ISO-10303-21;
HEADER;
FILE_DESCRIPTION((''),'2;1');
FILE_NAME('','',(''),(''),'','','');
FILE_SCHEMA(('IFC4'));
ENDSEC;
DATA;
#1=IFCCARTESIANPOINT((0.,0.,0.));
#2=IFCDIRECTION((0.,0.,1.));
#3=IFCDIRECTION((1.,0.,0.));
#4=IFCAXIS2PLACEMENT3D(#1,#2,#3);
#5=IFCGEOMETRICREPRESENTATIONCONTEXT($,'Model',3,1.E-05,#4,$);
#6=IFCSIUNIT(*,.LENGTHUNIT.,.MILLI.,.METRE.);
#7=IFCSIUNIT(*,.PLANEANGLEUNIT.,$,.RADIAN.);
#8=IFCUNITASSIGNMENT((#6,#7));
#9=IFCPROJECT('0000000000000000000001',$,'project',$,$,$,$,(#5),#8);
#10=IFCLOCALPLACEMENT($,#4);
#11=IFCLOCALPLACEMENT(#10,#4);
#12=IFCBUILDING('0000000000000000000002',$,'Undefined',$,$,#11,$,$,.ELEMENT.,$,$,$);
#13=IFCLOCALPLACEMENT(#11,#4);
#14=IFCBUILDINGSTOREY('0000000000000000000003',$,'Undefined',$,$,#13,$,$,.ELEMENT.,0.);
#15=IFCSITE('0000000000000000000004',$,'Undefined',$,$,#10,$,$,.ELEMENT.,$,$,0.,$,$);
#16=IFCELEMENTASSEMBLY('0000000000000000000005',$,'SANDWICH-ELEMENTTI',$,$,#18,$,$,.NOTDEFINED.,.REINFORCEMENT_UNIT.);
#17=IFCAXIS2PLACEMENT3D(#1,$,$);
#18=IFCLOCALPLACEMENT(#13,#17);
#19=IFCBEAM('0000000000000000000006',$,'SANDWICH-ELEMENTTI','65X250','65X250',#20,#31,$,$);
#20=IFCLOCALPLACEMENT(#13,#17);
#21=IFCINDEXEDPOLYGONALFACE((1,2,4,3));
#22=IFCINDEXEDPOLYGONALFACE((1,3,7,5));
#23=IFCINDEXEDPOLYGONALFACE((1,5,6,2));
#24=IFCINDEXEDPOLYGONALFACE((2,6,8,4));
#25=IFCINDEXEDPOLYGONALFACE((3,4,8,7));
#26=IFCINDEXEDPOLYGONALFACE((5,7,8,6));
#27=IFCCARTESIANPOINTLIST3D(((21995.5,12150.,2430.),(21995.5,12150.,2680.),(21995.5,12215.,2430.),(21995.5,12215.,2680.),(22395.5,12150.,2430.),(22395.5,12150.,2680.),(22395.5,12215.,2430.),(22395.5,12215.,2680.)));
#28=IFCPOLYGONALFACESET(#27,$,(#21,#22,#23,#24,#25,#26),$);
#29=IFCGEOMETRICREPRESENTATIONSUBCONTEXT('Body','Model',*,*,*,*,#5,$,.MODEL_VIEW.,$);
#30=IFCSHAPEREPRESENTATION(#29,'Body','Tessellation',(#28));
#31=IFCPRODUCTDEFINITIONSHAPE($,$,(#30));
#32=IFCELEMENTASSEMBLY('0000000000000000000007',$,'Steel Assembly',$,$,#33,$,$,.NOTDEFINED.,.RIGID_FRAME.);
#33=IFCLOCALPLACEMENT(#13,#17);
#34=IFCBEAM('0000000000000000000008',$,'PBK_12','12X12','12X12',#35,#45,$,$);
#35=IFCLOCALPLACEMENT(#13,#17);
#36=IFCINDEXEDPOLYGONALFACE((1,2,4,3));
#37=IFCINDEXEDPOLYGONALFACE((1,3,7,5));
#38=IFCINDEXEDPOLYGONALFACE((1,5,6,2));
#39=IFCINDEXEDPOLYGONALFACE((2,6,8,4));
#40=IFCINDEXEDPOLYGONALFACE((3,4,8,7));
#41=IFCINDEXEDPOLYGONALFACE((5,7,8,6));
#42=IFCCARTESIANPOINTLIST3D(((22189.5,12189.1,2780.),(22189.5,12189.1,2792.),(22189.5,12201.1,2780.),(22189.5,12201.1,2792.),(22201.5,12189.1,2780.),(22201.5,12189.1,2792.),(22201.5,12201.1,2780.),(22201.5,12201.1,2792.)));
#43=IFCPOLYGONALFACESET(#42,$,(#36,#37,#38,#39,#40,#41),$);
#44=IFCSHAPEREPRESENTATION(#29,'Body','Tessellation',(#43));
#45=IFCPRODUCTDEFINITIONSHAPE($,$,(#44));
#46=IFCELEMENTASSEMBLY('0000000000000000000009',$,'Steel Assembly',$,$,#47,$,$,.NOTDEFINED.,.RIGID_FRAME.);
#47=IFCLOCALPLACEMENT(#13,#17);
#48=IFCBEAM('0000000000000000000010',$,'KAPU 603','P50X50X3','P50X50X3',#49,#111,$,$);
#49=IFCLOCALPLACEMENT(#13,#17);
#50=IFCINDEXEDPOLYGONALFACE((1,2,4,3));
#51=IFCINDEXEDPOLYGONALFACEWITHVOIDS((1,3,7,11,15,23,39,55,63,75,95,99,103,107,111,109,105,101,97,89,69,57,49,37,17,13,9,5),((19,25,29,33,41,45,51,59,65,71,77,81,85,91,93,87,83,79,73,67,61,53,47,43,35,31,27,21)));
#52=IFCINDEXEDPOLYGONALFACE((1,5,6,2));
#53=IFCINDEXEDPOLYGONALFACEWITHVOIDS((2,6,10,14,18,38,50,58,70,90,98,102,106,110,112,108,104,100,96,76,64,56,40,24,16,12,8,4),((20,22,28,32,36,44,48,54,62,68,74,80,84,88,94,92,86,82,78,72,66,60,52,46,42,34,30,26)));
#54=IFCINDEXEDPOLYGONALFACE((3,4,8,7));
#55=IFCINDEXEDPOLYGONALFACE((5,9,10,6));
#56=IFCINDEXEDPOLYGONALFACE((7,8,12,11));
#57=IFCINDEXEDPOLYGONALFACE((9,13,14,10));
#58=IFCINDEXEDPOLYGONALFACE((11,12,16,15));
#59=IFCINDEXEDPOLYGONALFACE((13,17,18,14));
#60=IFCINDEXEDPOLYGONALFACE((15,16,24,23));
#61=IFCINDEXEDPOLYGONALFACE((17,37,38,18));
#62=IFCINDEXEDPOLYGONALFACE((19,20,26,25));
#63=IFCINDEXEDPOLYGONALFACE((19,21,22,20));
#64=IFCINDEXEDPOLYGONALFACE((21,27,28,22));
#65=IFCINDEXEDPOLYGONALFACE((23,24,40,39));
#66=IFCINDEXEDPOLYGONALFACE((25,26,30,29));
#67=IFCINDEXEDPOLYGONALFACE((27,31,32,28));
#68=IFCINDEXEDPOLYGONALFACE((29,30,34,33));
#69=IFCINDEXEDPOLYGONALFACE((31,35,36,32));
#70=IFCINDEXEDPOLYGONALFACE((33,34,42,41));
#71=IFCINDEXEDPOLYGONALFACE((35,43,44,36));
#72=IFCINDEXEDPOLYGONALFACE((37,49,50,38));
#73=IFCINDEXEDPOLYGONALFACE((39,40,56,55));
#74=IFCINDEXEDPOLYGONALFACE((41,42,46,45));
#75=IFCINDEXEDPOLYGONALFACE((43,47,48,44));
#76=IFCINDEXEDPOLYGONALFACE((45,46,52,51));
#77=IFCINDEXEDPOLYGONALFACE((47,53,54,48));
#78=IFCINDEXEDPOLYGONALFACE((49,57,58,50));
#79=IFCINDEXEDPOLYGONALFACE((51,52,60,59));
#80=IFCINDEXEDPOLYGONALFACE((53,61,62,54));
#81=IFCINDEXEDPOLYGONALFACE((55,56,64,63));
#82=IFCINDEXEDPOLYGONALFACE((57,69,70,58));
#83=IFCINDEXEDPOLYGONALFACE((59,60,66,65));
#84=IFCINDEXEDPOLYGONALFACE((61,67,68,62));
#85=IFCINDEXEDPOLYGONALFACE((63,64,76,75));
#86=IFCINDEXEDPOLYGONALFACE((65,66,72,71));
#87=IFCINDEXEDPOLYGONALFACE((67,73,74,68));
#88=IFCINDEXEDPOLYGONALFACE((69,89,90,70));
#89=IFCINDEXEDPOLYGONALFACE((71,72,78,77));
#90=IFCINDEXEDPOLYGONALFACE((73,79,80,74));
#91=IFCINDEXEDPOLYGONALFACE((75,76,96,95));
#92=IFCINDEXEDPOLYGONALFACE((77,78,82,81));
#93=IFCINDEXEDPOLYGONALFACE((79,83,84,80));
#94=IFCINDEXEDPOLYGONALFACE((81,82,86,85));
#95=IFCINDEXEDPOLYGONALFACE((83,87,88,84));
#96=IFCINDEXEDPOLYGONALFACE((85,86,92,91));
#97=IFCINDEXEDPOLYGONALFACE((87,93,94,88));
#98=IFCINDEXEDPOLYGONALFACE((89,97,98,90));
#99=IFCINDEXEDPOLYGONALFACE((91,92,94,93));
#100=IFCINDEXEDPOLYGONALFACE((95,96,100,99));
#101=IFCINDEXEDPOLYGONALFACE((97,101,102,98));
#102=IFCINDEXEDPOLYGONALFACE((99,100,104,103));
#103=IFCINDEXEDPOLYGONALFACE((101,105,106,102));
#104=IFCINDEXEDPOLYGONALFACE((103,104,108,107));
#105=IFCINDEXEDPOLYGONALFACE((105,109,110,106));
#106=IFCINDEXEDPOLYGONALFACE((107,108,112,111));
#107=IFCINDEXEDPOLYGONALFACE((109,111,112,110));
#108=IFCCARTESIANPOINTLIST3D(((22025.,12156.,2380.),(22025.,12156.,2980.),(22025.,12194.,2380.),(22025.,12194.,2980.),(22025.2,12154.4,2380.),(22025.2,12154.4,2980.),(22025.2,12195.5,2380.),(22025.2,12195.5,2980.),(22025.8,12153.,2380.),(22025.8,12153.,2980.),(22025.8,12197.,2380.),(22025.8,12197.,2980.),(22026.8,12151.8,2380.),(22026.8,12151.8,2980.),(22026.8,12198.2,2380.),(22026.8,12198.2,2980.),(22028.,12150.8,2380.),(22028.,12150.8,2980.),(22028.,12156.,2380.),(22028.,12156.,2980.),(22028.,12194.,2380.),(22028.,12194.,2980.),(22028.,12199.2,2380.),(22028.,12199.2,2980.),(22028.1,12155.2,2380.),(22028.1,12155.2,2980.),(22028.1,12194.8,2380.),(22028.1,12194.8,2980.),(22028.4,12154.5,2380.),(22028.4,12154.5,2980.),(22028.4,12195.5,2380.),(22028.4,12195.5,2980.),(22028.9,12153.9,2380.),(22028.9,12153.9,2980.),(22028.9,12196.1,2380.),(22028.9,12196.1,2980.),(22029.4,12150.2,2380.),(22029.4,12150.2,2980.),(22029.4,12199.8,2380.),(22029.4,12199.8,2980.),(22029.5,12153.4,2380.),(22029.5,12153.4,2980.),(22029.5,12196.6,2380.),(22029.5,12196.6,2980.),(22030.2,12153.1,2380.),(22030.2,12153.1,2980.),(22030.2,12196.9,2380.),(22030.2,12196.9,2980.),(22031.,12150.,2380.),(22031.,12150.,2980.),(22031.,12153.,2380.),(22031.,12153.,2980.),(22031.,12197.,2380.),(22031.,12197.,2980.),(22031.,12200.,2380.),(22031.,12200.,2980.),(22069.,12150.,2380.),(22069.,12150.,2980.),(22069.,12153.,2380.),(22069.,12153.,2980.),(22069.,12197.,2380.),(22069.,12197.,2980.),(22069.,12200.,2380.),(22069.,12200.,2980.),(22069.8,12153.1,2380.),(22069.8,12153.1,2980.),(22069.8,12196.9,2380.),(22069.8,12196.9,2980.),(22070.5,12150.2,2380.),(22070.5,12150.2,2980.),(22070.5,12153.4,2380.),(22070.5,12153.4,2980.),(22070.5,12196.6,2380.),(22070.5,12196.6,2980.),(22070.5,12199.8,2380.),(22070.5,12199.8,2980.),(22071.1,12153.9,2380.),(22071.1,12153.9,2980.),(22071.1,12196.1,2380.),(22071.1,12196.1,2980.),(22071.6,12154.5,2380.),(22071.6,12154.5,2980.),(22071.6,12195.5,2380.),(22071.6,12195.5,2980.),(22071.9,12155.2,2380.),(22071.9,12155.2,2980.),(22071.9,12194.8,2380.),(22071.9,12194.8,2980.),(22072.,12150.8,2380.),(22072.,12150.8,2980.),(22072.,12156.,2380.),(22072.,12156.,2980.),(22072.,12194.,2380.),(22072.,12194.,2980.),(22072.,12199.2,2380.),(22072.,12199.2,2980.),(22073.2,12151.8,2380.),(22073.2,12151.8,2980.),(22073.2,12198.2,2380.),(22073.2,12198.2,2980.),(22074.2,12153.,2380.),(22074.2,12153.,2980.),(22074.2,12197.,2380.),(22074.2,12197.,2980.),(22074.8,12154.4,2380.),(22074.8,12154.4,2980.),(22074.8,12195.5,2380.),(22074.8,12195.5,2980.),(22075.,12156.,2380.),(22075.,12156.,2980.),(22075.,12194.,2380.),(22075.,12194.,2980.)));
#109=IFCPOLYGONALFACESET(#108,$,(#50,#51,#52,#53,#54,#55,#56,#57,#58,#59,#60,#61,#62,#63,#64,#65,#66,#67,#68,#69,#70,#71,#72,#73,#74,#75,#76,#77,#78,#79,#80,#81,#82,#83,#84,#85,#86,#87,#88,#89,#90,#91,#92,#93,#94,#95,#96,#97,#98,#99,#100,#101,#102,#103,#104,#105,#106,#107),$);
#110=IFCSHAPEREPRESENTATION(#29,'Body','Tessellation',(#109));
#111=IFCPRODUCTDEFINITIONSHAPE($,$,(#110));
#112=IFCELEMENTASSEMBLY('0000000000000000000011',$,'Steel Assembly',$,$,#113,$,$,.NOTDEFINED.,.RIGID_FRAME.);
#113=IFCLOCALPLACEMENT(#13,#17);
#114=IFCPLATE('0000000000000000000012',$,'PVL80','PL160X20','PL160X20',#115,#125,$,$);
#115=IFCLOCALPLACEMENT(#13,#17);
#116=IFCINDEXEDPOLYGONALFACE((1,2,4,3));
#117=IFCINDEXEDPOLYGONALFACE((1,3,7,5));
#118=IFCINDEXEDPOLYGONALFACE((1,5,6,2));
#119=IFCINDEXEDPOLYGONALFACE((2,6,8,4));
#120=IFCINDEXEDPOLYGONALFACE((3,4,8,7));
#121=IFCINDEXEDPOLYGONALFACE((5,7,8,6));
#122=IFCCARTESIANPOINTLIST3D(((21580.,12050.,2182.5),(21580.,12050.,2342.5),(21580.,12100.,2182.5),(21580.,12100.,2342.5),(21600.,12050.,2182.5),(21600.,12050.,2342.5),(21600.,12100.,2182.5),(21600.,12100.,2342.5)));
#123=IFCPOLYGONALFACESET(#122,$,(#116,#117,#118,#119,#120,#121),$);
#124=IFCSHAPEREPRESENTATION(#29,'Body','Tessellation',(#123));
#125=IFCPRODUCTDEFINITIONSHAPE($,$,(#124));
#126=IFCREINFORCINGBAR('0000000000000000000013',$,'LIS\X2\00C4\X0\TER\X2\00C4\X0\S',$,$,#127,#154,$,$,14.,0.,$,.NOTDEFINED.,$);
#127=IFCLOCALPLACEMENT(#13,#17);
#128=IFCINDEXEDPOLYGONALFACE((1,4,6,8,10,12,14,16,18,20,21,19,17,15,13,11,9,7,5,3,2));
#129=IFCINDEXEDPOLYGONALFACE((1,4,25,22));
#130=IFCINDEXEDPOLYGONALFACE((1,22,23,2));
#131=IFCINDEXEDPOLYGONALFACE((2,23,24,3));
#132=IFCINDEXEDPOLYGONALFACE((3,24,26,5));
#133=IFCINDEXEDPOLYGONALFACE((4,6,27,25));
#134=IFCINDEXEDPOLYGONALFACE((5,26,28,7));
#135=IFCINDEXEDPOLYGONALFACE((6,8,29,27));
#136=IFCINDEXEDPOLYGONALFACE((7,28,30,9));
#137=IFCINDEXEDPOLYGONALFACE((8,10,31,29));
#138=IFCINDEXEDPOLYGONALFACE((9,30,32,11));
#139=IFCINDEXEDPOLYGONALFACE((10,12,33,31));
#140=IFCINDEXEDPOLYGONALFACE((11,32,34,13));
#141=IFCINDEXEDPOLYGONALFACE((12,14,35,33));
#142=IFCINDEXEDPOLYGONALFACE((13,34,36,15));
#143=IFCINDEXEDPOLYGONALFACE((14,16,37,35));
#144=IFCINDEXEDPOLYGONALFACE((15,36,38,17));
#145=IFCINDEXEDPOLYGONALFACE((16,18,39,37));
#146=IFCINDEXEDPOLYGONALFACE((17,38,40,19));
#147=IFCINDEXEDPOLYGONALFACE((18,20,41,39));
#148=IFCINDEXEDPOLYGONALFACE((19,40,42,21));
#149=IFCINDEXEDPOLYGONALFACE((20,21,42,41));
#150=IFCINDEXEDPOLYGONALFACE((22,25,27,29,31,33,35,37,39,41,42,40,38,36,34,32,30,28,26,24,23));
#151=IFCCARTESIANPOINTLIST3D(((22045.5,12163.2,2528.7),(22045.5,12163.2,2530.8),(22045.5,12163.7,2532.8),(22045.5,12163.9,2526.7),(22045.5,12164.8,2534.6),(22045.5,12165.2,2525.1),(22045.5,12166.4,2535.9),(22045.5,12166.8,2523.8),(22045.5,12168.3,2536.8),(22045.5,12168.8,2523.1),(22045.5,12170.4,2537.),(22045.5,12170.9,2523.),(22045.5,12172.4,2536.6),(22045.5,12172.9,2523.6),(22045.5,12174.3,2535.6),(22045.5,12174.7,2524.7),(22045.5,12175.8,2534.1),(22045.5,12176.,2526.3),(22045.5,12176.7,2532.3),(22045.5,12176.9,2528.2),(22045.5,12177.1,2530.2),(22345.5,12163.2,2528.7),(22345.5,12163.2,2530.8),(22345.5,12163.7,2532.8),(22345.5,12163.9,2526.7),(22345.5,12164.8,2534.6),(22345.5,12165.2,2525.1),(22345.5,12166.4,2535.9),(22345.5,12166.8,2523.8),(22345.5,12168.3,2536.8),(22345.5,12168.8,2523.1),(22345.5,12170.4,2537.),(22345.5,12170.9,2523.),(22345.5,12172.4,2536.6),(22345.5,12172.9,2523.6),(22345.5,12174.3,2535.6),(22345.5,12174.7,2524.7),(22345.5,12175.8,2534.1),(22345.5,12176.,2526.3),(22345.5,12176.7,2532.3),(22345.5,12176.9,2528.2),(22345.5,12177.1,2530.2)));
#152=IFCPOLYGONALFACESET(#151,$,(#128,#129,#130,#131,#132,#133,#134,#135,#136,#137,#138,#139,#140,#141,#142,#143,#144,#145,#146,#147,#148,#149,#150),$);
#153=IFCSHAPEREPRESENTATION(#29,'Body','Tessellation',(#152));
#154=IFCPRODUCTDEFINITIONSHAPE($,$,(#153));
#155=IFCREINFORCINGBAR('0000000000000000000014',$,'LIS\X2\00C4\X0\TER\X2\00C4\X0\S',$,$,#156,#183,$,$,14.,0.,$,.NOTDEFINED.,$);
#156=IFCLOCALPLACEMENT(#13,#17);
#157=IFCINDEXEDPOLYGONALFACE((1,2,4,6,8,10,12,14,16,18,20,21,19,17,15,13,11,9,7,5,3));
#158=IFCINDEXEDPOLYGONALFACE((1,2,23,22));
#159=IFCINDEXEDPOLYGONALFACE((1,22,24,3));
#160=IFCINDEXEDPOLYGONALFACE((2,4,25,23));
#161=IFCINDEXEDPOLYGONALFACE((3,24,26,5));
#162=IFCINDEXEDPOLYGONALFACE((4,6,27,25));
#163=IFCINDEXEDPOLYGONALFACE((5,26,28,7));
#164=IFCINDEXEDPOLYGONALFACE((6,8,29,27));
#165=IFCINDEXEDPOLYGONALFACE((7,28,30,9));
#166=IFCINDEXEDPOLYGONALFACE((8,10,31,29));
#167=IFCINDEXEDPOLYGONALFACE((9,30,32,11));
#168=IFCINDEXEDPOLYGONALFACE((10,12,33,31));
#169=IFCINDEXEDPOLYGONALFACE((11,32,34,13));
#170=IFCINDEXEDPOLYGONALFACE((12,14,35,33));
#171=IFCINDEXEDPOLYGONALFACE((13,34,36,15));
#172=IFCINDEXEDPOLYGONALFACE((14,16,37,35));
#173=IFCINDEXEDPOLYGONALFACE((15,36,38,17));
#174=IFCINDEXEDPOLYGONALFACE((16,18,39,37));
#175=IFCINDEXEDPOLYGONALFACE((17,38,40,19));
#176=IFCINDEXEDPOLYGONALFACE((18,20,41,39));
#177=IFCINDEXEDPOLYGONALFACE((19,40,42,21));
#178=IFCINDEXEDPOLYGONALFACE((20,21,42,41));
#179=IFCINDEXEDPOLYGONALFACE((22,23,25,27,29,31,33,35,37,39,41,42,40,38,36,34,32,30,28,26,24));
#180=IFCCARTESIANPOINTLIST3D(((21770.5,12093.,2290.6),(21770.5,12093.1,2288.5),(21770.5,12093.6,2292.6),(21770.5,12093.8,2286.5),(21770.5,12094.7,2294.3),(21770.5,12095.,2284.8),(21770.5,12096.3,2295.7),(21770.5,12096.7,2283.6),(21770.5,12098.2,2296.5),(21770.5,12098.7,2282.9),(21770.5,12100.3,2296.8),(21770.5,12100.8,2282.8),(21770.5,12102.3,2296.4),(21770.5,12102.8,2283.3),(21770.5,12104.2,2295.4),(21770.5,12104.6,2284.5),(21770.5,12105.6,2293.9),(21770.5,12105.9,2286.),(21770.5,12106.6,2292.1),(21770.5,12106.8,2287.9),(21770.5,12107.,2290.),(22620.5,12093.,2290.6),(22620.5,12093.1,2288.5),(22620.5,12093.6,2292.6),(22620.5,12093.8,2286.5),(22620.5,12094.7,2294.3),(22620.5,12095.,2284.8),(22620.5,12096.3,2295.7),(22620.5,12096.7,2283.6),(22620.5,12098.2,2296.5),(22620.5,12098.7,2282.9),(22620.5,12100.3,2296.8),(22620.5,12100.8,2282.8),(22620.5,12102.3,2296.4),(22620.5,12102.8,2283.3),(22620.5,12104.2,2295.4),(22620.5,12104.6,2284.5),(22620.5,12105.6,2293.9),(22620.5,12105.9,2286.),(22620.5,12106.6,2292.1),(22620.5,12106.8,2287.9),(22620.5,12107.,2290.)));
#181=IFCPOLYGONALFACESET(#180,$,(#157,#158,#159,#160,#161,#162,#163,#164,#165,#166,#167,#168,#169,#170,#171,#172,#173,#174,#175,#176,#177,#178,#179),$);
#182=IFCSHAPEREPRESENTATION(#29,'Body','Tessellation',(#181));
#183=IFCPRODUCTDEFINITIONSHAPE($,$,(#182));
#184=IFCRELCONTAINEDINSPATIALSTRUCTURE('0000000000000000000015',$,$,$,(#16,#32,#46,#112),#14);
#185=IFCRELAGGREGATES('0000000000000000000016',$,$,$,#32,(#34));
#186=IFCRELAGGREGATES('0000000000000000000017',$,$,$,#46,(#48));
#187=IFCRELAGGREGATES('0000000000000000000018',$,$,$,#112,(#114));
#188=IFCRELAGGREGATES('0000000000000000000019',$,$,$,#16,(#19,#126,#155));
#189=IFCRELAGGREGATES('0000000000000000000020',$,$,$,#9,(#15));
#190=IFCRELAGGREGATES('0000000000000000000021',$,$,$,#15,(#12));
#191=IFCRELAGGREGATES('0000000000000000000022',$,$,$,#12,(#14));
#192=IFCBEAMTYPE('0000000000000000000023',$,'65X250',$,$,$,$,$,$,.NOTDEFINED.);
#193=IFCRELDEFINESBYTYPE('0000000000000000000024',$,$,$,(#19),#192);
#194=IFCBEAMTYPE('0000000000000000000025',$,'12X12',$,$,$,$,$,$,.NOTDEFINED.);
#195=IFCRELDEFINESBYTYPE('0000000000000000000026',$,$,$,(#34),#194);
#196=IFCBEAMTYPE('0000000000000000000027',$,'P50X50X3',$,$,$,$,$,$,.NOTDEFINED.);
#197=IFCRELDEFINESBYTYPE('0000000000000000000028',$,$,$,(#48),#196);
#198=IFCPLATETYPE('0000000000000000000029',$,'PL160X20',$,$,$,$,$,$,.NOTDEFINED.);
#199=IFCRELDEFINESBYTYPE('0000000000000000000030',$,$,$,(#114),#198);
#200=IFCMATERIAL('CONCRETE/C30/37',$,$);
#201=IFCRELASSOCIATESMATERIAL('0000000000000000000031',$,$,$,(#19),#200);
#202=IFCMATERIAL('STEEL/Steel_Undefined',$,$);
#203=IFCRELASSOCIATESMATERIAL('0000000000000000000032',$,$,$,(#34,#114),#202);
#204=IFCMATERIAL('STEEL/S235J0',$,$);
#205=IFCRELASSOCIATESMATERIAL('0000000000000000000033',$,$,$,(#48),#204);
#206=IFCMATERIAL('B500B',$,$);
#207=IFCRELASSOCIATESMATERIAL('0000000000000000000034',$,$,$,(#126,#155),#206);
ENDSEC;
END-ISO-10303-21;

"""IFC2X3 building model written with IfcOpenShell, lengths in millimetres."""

from ifc_helpers import new_model, entity, si_unit, frame, origin_with_axes, origin_2d_with_axis, place, context, subcontext, project, spatial, polyline, rectangle, hollow_rectangle, outline, extrude, source, transform, mapped, material, type_object, element, aggregate, save


model = new_model("IFC2X3")

# Units and contexts
model_context = context("Model", 3, precision=1e-05, world=origin_with_axes())
body_context = subcontext(model_context, "Body", "Model", "MODEL_VIEW")
ifc_project = project(units=[si_unit("LENGTHUNIT", "METRE", prefix="MILLI"), si_unit("PLANEANGLEUNIT", "RADIAN")], contexts=[model_context])

# Site, building, storey
site_placement = place(None, origin_with_axes())
site = spatial("IfcSite", under=ifc_project, at=site_placement, Name="Undefined", CompositionType="ELEMENT", RefElevation=0.0)
building_placement = place(site_placement, origin_with_axes())
building = spatial("IfcBuilding", under=site, at=building_placement, Name="Undefined", CompositionType="ELEMENT")
storey_placement = place(building_placement, origin_with_axes())
storey = spatial("IfcBuildingStorey", under=building, at=storey_placement, Name="Undefined", CompositionType="ELEMENT", Elevation=0.0)

# Element assemblies, beams
assembly_1_placement = place(storey_placement, origin_with_axes())
assembly_1 = element("IfcElementAssembly", 1, at=assembly_1_placement, inside=storey, Name="SANDWICH-ELEMENTTI", AssemblyPlace="NOTDEFINED", PredefinedType="REINFORCEMENT_UNIT")
ifc_material_1 = material(Name="CONCRETE/C30/37")
beam_type_1 = type_object("IfcBeamType", Name="65X250", PredefinedType="NOTDEFINED")
beam_1_placement = place(assembly_1_placement, frame((21995.5, 12182.5, 2555.0), z_axis=(0.0, -1.0, 0.0), x_axis=(1.0, 0.0, 0.0)))
beam_1 = element("IfcBeam", 2, at=beam_1_placement, type_object=beam_type_1, material=ifc_material_1, Name="SANDWICH-ELEMENTTI", Description="65X250", ObjectType="65X250", context=body_context, shape_type="SweptSolid", body=[
    extrude(rectangle(XDim=250.0, YDim=65.0, at=origin_2d_with_axis()), frame((400.0, 0.0, 0.0), z_axis=(-1.0, 0.0, 0.0), x_axis=(0.0, -1.0, 0.0)), (0.0, 0.0, 1.0), 400.0),
])
assembly_2_placement = place(storey_placement, origin_with_axes())
assembly_2 = element("IfcElementAssembly", 3, at=assembly_2_placement, inside=storey, Name="Steel Assembly", AssemblyPlace="NOTDEFINED", PredefinedType="RIGID_FRAME")
ifc_material_2 = material(Name="STEEL/Steel_Undefined")
beam_type_2 = type_object("IfcBeamType", Name="12X12", PredefinedType="NOTDEFINED")
beam_2_placement = place(assembly_2_placement, frame((22201.5, 12195.1, 2786.0), z_axis=(0.0, 0.0, 1.0), x_axis=(-1.0, 0.0, 0.0)))
beam_2 = element("IfcBeam", 4, at=beam_2_placement, type_object=beam_type_2, material=ifc_material_2, Name="PBK_12", Description="12X12", ObjectType="12X12", context=body_context, shape_type="SweptSolid", body=[
    extrude(rectangle(XDim=12.0, YDim=12.0, at=origin_2d_with_axis()), frame((12.0, 0.0, 0.0), z_axis=(-1.0, 0.0, 0.0), x_axis=(0.0, -1.0, 0.0)), (0.0, 0.0, 1.0), 12.0),
])
aggregate(assembly_2, [beam_2])
assembly_3_placement = place(storey_placement, origin_with_axes())
assembly_3 = element("IfcElementAssembly", 5, at=assembly_3_placement, inside=storey, Name="Steel Assembly", AssemblyPlace="NOTDEFINED", PredefinedType="RIGID_FRAME")
ifc_material_3 = material(Name="STEEL/S235J0")
beam_type_3 = type_object("IfcBeamType", Name="P50X50X3", PredefinedType="NOTDEFINED")
beam_3_placement = place(assembly_3_placement, frame((22050.0, 12175.0, 2980.0), z_axis=(1.0, 0.0, 0.0), x_axis=(0.0, 0.0, -1.0)))
beam_3 = element("IfcBeam", 6, at=beam_3_placement, type_object=beam_type_3, material=ifc_material_3, Name="KAPU 603", Description="P50X50X3", ObjectType="P50X50X3", context=body_context, shape_type="SweptSolid", body=[
    extrude(hollow_rectangle(XDim=50.0, YDim=50.0, WallThickness=3.0, InnerFilletRadius=3.0, OuterFilletRadius=6.0, at=origin_2d_with_axis()), frame((600.0, 0.0, 0.0), z_axis=(-1.0, 0.0, 0.0), x_axis=(0.0, -1.0, 0.0)), (0.0, 0.0, 1.0), 600.0),
])
aggregate(assembly_3, [beam_3])

# Element assembly, plate
assembly_4_placement = place(storey_placement, origin_with_axes())
assembly_4 = element("IfcElementAssembly", 7, at=assembly_4_placement, inside=storey, Name="Steel Assembly", AssemblyPlace="NOTDEFINED", PredefinedType="RIGID_FRAME")
plate_type = type_object("IfcPlateType", Name="PL160X20", PredefinedType="NOTDEFINED")
plate_placement = place(assembly_4_placement, frame((21580.0, 12050.0, 2262.5), z_axis=(0.0, 0.0, -1.0), x_axis=(0.0, 1.0, 0.0)))
plate = element("IfcPlate", 8, at=plate_placement, type_object=plate_type, material=ifc_material_2, Name="PVL80", Description="PL160X20", ObjectType="PL160X20", context=body_context, shape_type="SweptSolid", body=[
    extrude(outline(polyline([(0.0, 0.0), (50.0, 0.0), (50.0, 20.0), (0.0, 20.0), (0.0, 0.0)])), frame((0.0, 0.0, -80.0), z_axis=(0.0, 0.0, 1.0), x_axis=(1.0, 0.0, 0.0)), (0.0, 0.0, 1.0), 160.0),
])
aggregate(assembly_4, [plate])

# Reinforcing bars
ifc_material_4 = material(Name="B500B")
shared_shape_1 = source(origin_with_axes(), body_context, "Body", "AdvancedSweptSolid", [
    entity("IfcSweptDiskSolid", entity("IfcTrimmedCurve", entity("IfcLine", entity("IfcCartesianPoint", [0.0, 0.0, 0.0]), entity("IfcVector", entity("IfcDirection", [1.0, 0.0, 0.0]), 1.0)), [entity("IfcParameterValue", 0.0)], [entity("IfcParameterValue", 300.0)], True, "PARAMETER"), 7.0, None, 0.0, 300.0),
])
reinforcing_bar_1_placement = place(assembly_1_placement, frame((22045.5, 12170.1, 2530.0), z_axis=(0.0, 0.110296, -0.993899), x_axis=(1.0, 0.0, 0.0)))
reinforcing_bar_1 = element("IfcReinforcingBar", 9, at=reinforcing_bar_1_placement, material=ifc_material_4, Name="LISÄTERÄS", BarRole="NOTDEFINED", CrossSectionArea=0.0, NominalDiameter=14.0, context=body_context, shape_type="MappedRepresentation", body=[
    mapped(shared_shape_1, transform((0.0, 0.0, 0.0))),
])
shared_shape_2 = source(origin_with_axes(), body_context, "Body", "AdvancedSweptSolid", [
    entity("IfcSweptDiskSolid", entity("IfcTrimmedCurve", entity("IfcLine", entity("IfcCartesianPoint", [0.0, 0.0, 0.0]), entity("IfcVector", entity("IfcDirection", [1.0, 0.0, 0.0]), 1.0)), [entity("IfcParameterValue", 0.0)], [entity("IfcParameterValue", 850.0)], True, "PARAMETER"), 7.0, None, 0.0, 850.0),
])
reinforcing_bar_2_placement = place(assembly_1_placement, frame((21770.5, 12100.0, 2289.8), z_axis=(0.0, 0.110296, -0.993899), x_axis=(1.0, 0.0, 0.0)))
reinforcing_bar_2 = element("IfcReinforcingBar", 10, at=reinforcing_bar_2_placement, material=ifc_material_4, Name="LISÄTERÄS", BarRole="NOTDEFINED", CrossSectionArea=0.0, NominalDiameter=14.0, context=body_context, shape_type="MappedRepresentation", body=[
    mapped(shared_shape_2, transform((0.0, 0.0, 0.0))),
])
aggregate(assembly_1, [beam_1, reinforcing_bar_1, reinforcing_bar_2])

save(model, "model.ifc")
